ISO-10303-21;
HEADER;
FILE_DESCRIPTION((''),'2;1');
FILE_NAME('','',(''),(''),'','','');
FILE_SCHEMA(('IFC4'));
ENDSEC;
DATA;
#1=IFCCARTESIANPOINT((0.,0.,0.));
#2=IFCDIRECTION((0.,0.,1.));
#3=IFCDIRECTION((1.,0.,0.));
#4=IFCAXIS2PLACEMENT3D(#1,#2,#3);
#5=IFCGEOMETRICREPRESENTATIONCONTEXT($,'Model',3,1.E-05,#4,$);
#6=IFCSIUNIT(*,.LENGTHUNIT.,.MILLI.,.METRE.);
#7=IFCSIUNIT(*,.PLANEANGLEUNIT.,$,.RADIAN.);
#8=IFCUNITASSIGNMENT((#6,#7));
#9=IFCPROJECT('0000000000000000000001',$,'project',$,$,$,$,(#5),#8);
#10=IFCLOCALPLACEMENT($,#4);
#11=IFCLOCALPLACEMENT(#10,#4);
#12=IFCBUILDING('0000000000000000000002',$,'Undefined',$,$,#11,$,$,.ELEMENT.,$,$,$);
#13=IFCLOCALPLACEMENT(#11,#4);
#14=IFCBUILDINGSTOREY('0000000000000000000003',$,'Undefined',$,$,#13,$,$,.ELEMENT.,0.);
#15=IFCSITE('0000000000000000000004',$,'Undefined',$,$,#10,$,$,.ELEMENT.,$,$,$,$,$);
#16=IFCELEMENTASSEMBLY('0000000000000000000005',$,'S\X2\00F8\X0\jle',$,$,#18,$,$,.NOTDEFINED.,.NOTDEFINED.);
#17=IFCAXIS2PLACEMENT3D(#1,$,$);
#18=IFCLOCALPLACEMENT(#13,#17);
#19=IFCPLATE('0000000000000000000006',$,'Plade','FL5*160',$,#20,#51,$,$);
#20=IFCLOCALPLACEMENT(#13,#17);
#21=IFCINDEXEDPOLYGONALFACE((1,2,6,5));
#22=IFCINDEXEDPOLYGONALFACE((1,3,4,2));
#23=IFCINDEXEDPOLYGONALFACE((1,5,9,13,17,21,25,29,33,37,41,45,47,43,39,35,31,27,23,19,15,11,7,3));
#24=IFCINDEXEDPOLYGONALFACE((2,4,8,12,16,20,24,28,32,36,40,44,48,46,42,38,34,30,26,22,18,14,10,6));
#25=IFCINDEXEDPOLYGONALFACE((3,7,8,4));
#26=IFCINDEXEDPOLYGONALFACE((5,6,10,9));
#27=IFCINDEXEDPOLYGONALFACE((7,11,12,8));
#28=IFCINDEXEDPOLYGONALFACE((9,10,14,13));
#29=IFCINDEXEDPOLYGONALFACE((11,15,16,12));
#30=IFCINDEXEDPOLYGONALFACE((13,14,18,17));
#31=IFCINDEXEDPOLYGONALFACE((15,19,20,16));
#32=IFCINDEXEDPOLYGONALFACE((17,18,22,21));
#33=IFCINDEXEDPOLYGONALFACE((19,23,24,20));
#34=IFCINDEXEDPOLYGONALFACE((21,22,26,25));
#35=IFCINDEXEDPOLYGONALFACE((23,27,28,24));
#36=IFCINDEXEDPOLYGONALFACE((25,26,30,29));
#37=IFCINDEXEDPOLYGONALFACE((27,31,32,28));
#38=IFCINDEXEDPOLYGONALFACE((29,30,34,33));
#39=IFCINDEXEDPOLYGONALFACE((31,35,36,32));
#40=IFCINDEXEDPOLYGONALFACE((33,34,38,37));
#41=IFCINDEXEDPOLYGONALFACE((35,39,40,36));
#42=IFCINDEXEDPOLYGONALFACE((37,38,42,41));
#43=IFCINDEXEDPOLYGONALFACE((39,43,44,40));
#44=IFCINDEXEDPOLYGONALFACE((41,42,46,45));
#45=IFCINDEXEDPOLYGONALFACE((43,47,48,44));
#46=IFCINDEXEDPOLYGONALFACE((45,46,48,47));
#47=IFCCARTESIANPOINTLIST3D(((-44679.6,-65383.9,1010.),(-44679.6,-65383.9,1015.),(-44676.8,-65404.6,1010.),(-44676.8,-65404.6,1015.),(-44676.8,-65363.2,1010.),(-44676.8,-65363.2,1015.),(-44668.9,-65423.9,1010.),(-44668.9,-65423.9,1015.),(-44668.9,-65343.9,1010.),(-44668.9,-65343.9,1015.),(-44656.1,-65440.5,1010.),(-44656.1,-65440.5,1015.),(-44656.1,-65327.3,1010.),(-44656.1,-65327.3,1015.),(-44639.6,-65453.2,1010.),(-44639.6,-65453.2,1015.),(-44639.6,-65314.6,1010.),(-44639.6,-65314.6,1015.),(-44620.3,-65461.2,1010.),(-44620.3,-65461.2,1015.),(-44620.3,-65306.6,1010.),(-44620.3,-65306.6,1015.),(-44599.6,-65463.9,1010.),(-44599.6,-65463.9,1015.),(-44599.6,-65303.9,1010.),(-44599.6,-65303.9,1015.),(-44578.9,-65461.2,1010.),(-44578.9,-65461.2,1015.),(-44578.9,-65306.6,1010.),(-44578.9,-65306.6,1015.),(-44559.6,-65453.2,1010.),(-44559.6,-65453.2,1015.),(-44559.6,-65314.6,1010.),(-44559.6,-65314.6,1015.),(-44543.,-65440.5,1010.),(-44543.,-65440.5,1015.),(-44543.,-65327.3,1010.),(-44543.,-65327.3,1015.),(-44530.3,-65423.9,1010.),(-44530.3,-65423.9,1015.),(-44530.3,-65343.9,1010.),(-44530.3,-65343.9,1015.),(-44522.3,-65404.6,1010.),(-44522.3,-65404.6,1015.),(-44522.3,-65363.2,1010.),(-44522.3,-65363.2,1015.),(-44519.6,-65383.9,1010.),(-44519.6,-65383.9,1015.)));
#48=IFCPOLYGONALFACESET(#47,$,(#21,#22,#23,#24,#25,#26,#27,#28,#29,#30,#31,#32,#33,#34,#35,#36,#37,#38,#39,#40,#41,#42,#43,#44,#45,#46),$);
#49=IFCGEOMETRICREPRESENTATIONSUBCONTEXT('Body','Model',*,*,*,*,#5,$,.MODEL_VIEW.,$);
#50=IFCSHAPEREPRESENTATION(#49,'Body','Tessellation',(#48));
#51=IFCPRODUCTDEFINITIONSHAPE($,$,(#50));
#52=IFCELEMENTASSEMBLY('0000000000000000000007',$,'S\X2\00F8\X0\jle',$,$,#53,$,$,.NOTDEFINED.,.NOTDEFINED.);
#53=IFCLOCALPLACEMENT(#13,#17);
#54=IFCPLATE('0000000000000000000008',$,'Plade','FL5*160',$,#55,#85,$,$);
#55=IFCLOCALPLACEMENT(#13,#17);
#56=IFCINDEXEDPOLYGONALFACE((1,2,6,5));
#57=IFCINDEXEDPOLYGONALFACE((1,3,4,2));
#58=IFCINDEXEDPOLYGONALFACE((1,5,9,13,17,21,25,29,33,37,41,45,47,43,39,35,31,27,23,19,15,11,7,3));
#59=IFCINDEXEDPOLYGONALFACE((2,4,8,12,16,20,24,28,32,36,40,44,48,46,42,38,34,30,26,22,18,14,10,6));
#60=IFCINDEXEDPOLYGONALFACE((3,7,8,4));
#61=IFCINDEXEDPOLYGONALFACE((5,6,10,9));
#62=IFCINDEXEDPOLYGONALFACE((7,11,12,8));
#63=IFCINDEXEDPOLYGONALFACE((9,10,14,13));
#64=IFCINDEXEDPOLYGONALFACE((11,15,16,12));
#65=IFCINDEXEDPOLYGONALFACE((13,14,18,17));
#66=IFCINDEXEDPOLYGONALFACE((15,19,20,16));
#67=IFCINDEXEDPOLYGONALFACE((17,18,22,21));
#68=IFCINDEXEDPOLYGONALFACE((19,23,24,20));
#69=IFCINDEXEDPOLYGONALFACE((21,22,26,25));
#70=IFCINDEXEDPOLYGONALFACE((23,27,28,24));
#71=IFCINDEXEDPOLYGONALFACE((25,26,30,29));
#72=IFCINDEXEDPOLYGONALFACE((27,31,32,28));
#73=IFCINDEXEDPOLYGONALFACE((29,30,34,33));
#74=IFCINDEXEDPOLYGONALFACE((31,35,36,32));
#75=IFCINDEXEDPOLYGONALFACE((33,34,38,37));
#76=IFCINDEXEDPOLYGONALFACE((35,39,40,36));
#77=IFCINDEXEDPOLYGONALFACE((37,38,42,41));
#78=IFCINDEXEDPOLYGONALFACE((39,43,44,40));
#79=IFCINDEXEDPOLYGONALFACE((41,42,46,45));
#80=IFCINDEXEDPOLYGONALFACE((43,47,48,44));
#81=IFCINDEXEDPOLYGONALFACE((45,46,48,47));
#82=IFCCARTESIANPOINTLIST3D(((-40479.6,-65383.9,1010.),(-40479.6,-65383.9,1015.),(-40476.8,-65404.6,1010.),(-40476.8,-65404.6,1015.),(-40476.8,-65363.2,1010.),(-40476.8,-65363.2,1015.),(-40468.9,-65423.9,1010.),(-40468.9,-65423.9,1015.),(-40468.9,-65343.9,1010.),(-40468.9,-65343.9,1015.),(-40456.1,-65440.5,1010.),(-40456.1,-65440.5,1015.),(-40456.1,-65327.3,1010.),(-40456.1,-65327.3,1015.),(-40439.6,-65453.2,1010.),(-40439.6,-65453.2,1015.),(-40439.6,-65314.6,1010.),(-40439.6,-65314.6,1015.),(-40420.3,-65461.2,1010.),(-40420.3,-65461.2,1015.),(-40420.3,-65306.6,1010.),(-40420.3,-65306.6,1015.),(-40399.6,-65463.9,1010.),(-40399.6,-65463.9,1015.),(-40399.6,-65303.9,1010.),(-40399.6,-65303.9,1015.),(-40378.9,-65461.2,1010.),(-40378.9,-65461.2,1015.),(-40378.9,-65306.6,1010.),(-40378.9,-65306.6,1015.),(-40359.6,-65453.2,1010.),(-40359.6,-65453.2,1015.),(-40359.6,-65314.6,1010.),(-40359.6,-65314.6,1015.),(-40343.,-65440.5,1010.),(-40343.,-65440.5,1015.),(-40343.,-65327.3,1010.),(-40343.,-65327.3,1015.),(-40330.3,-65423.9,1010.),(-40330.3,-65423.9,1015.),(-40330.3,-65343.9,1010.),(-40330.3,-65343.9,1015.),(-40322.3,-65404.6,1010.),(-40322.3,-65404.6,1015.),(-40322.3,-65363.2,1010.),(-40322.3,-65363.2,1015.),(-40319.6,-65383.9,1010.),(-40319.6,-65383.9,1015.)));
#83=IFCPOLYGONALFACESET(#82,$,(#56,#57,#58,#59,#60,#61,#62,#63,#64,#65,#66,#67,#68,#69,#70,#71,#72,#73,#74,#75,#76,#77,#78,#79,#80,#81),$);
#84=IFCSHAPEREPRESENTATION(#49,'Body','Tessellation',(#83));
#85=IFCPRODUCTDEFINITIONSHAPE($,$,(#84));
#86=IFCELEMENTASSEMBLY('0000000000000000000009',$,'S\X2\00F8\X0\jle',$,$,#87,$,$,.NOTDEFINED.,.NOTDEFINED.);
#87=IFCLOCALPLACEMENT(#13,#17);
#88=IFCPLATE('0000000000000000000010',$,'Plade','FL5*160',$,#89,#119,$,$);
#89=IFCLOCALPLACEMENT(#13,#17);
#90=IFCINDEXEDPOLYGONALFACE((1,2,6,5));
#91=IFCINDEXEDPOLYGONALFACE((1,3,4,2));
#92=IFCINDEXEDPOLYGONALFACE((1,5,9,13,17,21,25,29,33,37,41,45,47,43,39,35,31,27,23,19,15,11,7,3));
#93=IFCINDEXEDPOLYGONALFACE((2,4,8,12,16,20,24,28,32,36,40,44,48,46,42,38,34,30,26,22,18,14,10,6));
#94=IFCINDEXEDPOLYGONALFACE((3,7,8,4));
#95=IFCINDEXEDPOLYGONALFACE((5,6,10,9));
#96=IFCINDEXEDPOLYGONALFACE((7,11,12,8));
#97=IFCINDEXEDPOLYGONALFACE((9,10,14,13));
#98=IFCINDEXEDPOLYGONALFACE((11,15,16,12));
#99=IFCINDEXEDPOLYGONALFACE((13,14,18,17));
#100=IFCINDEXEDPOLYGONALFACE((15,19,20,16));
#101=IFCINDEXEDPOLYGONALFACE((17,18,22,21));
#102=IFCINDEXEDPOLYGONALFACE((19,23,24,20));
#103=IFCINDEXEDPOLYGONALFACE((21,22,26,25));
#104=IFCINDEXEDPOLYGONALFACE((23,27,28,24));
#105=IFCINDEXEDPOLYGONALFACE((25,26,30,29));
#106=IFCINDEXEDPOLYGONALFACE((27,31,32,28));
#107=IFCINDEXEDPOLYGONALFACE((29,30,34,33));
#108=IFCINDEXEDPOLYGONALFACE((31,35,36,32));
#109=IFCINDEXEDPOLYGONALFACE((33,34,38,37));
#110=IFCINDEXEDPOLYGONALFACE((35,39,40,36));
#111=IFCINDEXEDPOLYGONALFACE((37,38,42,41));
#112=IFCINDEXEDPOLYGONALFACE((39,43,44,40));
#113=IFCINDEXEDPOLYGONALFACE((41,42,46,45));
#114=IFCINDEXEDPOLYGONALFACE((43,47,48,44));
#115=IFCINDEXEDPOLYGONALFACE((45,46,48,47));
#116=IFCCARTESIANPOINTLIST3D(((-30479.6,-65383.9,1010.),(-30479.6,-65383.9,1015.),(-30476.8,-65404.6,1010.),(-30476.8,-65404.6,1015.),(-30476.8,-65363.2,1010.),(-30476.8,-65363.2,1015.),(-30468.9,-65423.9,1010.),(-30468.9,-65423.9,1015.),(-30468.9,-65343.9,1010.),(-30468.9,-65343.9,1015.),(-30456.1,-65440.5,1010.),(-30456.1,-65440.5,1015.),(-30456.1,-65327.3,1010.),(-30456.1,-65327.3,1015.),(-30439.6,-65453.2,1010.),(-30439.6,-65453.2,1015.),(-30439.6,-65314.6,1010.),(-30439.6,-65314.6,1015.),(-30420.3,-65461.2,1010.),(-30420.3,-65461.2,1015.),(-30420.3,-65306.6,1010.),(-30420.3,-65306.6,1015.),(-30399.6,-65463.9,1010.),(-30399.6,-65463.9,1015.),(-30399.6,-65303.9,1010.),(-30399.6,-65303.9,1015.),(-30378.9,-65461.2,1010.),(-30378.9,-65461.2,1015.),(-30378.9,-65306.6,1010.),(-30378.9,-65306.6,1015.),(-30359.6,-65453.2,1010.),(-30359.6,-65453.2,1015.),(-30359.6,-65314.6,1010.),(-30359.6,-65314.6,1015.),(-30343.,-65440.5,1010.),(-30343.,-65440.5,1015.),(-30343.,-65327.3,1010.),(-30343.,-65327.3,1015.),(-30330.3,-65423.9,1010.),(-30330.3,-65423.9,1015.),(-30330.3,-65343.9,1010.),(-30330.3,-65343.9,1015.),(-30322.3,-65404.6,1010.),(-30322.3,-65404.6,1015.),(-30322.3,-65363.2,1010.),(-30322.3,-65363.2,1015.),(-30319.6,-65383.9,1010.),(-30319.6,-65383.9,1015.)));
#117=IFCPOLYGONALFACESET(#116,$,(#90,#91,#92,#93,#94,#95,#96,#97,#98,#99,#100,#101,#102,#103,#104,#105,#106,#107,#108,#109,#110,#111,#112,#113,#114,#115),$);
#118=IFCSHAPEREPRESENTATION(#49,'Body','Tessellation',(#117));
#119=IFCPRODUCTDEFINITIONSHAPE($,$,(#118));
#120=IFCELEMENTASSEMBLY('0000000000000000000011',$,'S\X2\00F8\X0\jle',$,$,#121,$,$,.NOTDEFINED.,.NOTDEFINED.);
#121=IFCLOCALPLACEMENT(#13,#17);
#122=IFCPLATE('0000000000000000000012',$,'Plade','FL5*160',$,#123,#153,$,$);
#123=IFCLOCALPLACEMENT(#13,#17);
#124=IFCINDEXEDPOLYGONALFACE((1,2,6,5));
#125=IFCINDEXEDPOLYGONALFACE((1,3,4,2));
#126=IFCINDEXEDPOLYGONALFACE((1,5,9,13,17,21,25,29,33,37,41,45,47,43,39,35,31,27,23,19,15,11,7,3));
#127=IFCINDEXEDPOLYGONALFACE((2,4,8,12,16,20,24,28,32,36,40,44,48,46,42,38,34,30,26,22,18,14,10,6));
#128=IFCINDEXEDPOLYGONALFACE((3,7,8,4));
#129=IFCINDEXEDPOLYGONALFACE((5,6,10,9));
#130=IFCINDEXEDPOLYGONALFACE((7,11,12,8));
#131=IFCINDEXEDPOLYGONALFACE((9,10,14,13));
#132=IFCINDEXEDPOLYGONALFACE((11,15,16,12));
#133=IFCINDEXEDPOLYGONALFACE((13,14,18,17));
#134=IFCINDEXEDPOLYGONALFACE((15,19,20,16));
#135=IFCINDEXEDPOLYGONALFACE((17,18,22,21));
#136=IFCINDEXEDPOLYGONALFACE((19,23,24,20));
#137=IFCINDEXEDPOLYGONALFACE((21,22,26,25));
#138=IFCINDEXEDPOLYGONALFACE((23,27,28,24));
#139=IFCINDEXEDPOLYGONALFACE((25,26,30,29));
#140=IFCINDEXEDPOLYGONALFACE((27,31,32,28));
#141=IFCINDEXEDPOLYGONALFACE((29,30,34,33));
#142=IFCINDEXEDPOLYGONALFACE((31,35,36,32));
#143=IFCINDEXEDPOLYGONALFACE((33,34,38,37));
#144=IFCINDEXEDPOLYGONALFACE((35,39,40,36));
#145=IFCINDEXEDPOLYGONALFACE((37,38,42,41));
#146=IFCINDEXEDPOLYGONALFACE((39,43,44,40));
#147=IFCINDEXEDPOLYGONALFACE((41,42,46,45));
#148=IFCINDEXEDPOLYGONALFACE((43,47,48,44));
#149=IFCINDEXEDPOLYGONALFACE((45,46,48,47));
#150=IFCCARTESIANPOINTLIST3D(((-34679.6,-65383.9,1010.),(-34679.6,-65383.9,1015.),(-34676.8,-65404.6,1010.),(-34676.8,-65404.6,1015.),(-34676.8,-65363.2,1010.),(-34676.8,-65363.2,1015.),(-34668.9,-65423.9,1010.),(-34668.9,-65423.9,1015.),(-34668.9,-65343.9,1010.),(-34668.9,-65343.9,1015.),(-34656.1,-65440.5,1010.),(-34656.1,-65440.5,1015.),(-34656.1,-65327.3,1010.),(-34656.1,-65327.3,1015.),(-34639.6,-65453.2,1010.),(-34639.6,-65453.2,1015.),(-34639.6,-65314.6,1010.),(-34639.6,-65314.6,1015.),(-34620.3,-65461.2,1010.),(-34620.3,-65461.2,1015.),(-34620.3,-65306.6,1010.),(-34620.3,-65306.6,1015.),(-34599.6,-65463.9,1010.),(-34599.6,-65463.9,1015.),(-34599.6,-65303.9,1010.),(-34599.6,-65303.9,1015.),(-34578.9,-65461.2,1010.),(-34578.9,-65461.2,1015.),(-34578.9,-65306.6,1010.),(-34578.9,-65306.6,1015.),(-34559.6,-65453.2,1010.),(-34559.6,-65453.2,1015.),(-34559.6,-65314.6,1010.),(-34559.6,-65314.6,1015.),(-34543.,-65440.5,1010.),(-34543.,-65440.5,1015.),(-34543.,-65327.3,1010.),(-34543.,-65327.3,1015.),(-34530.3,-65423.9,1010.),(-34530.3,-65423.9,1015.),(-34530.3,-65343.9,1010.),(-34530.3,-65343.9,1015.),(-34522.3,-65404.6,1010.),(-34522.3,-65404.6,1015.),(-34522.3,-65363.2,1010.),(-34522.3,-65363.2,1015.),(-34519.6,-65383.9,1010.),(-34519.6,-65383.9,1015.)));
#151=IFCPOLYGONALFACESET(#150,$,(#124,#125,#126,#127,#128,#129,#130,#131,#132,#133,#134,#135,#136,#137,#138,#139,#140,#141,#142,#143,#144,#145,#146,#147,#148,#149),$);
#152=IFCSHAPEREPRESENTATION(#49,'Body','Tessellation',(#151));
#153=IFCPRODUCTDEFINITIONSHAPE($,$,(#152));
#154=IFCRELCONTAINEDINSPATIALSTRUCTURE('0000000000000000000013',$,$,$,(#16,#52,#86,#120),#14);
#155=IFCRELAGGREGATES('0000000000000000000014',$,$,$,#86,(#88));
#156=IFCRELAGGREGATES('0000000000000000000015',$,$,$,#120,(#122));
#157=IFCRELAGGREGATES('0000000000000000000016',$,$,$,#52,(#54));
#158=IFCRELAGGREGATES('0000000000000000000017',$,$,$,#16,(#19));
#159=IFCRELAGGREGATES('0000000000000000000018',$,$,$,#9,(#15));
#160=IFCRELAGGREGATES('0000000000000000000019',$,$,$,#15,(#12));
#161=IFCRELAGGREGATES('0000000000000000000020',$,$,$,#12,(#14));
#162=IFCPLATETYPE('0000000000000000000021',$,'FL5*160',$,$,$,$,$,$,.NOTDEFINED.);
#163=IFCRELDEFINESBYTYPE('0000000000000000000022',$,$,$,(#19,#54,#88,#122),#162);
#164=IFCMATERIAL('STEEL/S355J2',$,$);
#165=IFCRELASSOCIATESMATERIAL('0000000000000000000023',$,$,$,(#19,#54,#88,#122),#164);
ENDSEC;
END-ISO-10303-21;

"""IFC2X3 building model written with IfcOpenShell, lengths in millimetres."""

from ifc_helpers import new_model, si_unit, frame, frame_2d, origin_with_axes, place, context, subcontext, project, spatial, polyline, circle_curve, parameter, trimmed, segment, composite_curve, outline, extrude, material, type_object, element, aggregate, save


model = new_model("IFC2X3")

# Units and contexts
model_context = context("Model", 3, precision=1e-05, world=origin_with_axes())
body_context = subcontext(model_context, "Body", "Model", "MODEL_VIEW")
ifc_project = project(units=[si_unit("LENGTHUNIT", "METRE", prefix="MILLI"), si_unit("PLANEANGLEUNIT", "RADIAN")], contexts=[model_context])

# Site, building, storey
site_placement = place(None, origin_with_axes())
site = spatial("IfcSite", under=ifc_project, at=site_placement, Name="Undefined", CompositionType="ELEMENT")
building_placement = place(site_placement, origin_with_axes())
building = spatial("IfcBuilding", under=site, at=building_placement, Name="Undefined", CompositionType="ELEMENT")
storey_placement = place(building_placement, origin_with_axes())
storey = spatial("IfcBuildingStorey", under=building, at=storey_placement, Name="Undefined", CompositionType="ELEMENT", Elevation=0.0)

# Element assembly
assembly_1_placement = place(storey_placement, origin_with_axes())
assembly_1 = element("IfcElementAssembly", 1, at=assembly_1_placement, inside=storey, Name="Søjle", AssemblyPlace="NOTDEFINED", PredefinedType="NOTDEFINED")
ifc_material_1 = material(Name="STEEL/S355J2")

# Plate
plate_type_1 = type_object("IfcPlateType", Name="FL5*160", PredefinedType="NOTDEFINED")
plate_1_placement = place(assembly_1_placement, frame((-44519.6, -65303.9, 1012.5), z_axis=(0.0, 0.0, 1.0), x_axis=(-1.0, 0.0, 0.0)))
plate_1 = element("IfcPlate", 2, at=plate_1_placement, type_object=plate_type_1, material=ifc_material_1, Name="Plade", Description="FL5*160", context=body_context, shape_type="SweptSolid", body=[
    extrude(outline(composite_curve([segment(trimmed(circle_curve(frame_2d((80.0, 80.0), x_axis=(-1.0, 0.0)), 80.0), [parameter(0.0)], [parameter(1.570796)], True, "PARAMETER"), True, "CONTINUOUS"), segment(polyline([(80.0, 0.0), (80.0, 0.0)]), True, "CONTINUOUS"), segment(trimmed(circle_curve(frame_2d((80.0, 80.0), x_axis=(0.0, -1.0)), 80.0), [parameter(0.0)], [parameter(1.570796)], True, "PARAMETER"), True, "CONTINUOUS"), segment(polyline([(160.0, 80.0), (160.0, 80.0)]), True, "CONTINUOUS"), segment(trimmed(circle_curve(frame_2d((80.0, 80.0), x_axis=(1.0, 0.0)), 80.0), [parameter(0.0)], [parameter(1.570796)], True, "PARAMETER"), True, "CONTINUOUS"), segment(polyline([(80.0, 160.0), (80.0, 160.0)]), True, "CONTINUOUS"), segment(trimmed(circle_curve(frame_2d((80.0, 80.0), x_axis=(0.0, 1.0)), 80.0), [parameter(0.0)], [parameter(1.570796)], True, "PARAMETER"), True, "CONTINUOUS"), segment(polyline([(0.0, 80.0), (0.0, 80.0)]), True, "CONTINUOUS")], self_intersect=True)), frame((0.0, 0.0, -2.5), z_axis=(0.0, 0.0, 1.0), x_axis=(1.0, 0.0, 0.0)), (0.0, 0.0, 1.0), 5.0),
])

# Element assemblies, plates
assembly_2_placement = place(storey_placement, origin_with_axes())
assembly_2 = element("IfcElementAssembly", 3, at=assembly_2_placement, inside=storey, Name="Søjle", AssemblyPlace="NOTDEFINED", PredefinedType="NOTDEFINED")
plate_2_placement = place(assembly_2_placement, frame((-40319.6, -65303.9, 1012.5), z_axis=(0.0, 0.0, 1.0), x_axis=(-1.0, 0.0, 0.0)))
plate_2 = element("IfcPlate", 4, at=plate_2_placement, type_object=plate_type_1, material=ifc_material_1, Name="Plade", Description="FL5*160", context=body_context, shape_type="SweptSolid", body=[
    extrude(outline(composite_curve([segment(trimmed(circle_curve(frame_2d((80.0, 80.0), x_axis=(-1.0, 0.0)), 80.0), [parameter(0.0)], [parameter(1.570796)], True, "PARAMETER"), True, "CONTINUOUS"), segment(polyline([(80.0, 0.0), (80.0, 0.0)]), True, "CONTINUOUS"), segment(trimmed(circle_curve(frame_2d((80.0, 80.0), x_axis=(0.0, -1.0)), 80.0), [parameter(0.0)], [parameter(1.570796)], True, "PARAMETER"), True, "CONTINUOUS"), segment(polyline([(160.0, 80.0), (160.0, 80.0)]), True, "CONTINUOUS"), segment(trimmed(circle_curve(frame_2d((80.0, 80.0), x_axis=(1.0, 0.0)), 80.0), [parameter(0.0)], [parameter(1.570796)], True, "PARAMETER"), True, "CONTINUOUS"), segment(polyline([(80.0, 160.0), (80.0, 160.0)]), True, "CONTINUOUS"), segment(trimmed(circle_curve(frame_2d((80.0, 80.0), x_axis=(0.0, 1.0)), 80.0), [parameter(0.0)], [parameter(1.570796)], True, "PARAMETER"), True, "CONTINUOUS"), segment(polyline([(0.0, 80.0), (0.0, 80.0)]), True, "CONTINUOUS")], self_intersect=True)), frame((0.0, 0.0, -2.5), z_axis=(0.0, 0.0, 1.0), x_axis=(1.0, 0.0, 0.0)), (0.0, 0.0, 1.0), 5.0),
])
assembly_3_placement = place(storey_placement, origin_with_axes())
assembly_3 = element("IfcElementAssembly", 5, at=assembly_3_placement, inside=storey, Name="Søjle", AssemblyPlace="NOTDEFINED", PredefinedType="NOTDEFINED")
plate_3_placement = place(assembly_3_placement, frame((-30319.6, -65303.9, 1012.5), z_axis=(0.0, 0.0, 1.0), x_axis=(-1.0, 0.0, 0.0)))
plate_3 = element("IfcPlate", 6, at=plate_3_placement, type_object=plate_type_1, material=ifc_material_1, Name="Plade", Description="FL5*160", context=body_context, shape_type="SweptSolid", body=[
    extrude(outline(composite_curve([segment(trimmed(circle_curve(frame_2d((80.0, 80.0), x_axis=(-1.0, 0.0)), 80.0), [parameter(0.0)], [parameter(1.570796)], True, "PARAMETER"), True, "CONTINUOUS"), segment(polyline([(80.0, 0.0), (80.0, 0.0)]), True, "CONTINUOUS"), segment(trimmed(circle_curve(frame_2d((80.0, 80.0), x_axis=(0.0, -1.0)), 80.0), [parameter(0.0)], [parameter(1.570796)], True, "PARAMETER"), True, "CONTINUOUS"), segment(polyline([(160.0, 80.0), (160.0, 80.0)]), True, "CONTINUOUS"), segment(trimmed(circle_curve(frame_2d((80.0, 80.0), x_axis=(1.0, 0.0)), 80.0), [parameter(0.0)], [parameter(1.570796)], True, "PARAMETER"), True, "CONTINUOUS"), segment(polyline([(80.0, 160.0), (80.0, 160.0)]), True, "CONTINUOUS"), segment(trimmed(circle_curve(frame_2d((80.0, 80.0), x_axis=(0.0, 1.0)), 80.0), [parameter(0.0)], [parameter(1.570796)], True, "PARAMETER"), True, "CONTINUOUS"), segment(polyline([(0.0, 80.0), (0.0, 80.0)]), True, "CONTINUOUS")], self_intersect=True)), frame((0.0, 0.0, -2.5), z_axis=(0.0, 0.0, 1.0), x_axis=(1.0, 0.0, 0.0)), (0.0, 0.0, 1.0), 5.0),
])
assembly_4_placement = place(storey_placement, origin_with_axes())
assembly_4 = element("IfcElementAssembly", 7, at=assembly_4_placement, inside=storey, Name="Søjle", AssemblyPlace="NOTDEFINED", PredefinedType="NOTDEFINED")
plate_4_placement = place(assembly_4_placement, frame((-34519.6, -65303.9, 1012.5), z_axis=(0.0, 0.0, 1.0), x_axis=(-1.0, 0.0, 0.0)))
plate_4 = element("IfcPlate", 8, at=plate_4_placement, type_object=plate_type_1, material=ifc_material_1, Name="Plade", Description="FL5*160", context=body_context, shape_type="SweptSolid", body=[
    extrude(outline(composite_curve([segment(trimmed(circle_curve(frame_2d((80.0, 80.0), x_axis=(-1.0, 0.0)), 80.0), [parameter(0.0)], [parameter(1.570796)], True, "PARAMETER"), True, "CONTINUOUS"), segment(polyline([(80.0, 0.0), (80.0, 0.0)]), True, "CONTINUOUS"), segment(trimmed(circle_curve(frame_2d((80.0, 80.0), x_axis=(0.0, -1.0)), 80.0), [parameter(0.0)], [parameter(1.570796)], True, "PARAMETER"), True, "CONTINUOUS"), segment(polyline([(160.0, 80.0), (160.0, 80.0)]), True, "CONTINUOUS"), segment(trimmed(circle_curve(frame_2d((80.0, 80.0), x_axis=(1.0, 0.0)), 80.0), [parameter(0.0)], [parameter(1.570796)], True, "PARAMETER"), True, "CONTINUOUS"), segment(polyline([(80.0, 160.0), (80.0, 160.0)]), True, "CONTINUOUS"), segment(trimmed(circle_curve(frame_2d((80.0, 80.0), x_axis=(0.0, 1.0)), 80.0), [parameter(0.0)], [parameter(1.570796)], True, "PARAMETER"), True, "CONTINUOUS"), segment(polyline([(0.0, 80.0), (0.0, 80.0)]), True, "CONTINUOUS")], self_intersect=True)), frame((0.0, 0.0, -2.5), z_axis=(0.0, 0.0, 1.0), x_axis=(1.0, 0.0, 0.0)), (0.0, 0.0, 1.0), 5.0),
])

aggregate(assembly_3, [plate_3])
aggregate(assembly_4, [plate_4])
aggregate(assembly_2, [plate_2])
aggregate(assembly_1, [plate_1])

save(model, "model.ifc")
